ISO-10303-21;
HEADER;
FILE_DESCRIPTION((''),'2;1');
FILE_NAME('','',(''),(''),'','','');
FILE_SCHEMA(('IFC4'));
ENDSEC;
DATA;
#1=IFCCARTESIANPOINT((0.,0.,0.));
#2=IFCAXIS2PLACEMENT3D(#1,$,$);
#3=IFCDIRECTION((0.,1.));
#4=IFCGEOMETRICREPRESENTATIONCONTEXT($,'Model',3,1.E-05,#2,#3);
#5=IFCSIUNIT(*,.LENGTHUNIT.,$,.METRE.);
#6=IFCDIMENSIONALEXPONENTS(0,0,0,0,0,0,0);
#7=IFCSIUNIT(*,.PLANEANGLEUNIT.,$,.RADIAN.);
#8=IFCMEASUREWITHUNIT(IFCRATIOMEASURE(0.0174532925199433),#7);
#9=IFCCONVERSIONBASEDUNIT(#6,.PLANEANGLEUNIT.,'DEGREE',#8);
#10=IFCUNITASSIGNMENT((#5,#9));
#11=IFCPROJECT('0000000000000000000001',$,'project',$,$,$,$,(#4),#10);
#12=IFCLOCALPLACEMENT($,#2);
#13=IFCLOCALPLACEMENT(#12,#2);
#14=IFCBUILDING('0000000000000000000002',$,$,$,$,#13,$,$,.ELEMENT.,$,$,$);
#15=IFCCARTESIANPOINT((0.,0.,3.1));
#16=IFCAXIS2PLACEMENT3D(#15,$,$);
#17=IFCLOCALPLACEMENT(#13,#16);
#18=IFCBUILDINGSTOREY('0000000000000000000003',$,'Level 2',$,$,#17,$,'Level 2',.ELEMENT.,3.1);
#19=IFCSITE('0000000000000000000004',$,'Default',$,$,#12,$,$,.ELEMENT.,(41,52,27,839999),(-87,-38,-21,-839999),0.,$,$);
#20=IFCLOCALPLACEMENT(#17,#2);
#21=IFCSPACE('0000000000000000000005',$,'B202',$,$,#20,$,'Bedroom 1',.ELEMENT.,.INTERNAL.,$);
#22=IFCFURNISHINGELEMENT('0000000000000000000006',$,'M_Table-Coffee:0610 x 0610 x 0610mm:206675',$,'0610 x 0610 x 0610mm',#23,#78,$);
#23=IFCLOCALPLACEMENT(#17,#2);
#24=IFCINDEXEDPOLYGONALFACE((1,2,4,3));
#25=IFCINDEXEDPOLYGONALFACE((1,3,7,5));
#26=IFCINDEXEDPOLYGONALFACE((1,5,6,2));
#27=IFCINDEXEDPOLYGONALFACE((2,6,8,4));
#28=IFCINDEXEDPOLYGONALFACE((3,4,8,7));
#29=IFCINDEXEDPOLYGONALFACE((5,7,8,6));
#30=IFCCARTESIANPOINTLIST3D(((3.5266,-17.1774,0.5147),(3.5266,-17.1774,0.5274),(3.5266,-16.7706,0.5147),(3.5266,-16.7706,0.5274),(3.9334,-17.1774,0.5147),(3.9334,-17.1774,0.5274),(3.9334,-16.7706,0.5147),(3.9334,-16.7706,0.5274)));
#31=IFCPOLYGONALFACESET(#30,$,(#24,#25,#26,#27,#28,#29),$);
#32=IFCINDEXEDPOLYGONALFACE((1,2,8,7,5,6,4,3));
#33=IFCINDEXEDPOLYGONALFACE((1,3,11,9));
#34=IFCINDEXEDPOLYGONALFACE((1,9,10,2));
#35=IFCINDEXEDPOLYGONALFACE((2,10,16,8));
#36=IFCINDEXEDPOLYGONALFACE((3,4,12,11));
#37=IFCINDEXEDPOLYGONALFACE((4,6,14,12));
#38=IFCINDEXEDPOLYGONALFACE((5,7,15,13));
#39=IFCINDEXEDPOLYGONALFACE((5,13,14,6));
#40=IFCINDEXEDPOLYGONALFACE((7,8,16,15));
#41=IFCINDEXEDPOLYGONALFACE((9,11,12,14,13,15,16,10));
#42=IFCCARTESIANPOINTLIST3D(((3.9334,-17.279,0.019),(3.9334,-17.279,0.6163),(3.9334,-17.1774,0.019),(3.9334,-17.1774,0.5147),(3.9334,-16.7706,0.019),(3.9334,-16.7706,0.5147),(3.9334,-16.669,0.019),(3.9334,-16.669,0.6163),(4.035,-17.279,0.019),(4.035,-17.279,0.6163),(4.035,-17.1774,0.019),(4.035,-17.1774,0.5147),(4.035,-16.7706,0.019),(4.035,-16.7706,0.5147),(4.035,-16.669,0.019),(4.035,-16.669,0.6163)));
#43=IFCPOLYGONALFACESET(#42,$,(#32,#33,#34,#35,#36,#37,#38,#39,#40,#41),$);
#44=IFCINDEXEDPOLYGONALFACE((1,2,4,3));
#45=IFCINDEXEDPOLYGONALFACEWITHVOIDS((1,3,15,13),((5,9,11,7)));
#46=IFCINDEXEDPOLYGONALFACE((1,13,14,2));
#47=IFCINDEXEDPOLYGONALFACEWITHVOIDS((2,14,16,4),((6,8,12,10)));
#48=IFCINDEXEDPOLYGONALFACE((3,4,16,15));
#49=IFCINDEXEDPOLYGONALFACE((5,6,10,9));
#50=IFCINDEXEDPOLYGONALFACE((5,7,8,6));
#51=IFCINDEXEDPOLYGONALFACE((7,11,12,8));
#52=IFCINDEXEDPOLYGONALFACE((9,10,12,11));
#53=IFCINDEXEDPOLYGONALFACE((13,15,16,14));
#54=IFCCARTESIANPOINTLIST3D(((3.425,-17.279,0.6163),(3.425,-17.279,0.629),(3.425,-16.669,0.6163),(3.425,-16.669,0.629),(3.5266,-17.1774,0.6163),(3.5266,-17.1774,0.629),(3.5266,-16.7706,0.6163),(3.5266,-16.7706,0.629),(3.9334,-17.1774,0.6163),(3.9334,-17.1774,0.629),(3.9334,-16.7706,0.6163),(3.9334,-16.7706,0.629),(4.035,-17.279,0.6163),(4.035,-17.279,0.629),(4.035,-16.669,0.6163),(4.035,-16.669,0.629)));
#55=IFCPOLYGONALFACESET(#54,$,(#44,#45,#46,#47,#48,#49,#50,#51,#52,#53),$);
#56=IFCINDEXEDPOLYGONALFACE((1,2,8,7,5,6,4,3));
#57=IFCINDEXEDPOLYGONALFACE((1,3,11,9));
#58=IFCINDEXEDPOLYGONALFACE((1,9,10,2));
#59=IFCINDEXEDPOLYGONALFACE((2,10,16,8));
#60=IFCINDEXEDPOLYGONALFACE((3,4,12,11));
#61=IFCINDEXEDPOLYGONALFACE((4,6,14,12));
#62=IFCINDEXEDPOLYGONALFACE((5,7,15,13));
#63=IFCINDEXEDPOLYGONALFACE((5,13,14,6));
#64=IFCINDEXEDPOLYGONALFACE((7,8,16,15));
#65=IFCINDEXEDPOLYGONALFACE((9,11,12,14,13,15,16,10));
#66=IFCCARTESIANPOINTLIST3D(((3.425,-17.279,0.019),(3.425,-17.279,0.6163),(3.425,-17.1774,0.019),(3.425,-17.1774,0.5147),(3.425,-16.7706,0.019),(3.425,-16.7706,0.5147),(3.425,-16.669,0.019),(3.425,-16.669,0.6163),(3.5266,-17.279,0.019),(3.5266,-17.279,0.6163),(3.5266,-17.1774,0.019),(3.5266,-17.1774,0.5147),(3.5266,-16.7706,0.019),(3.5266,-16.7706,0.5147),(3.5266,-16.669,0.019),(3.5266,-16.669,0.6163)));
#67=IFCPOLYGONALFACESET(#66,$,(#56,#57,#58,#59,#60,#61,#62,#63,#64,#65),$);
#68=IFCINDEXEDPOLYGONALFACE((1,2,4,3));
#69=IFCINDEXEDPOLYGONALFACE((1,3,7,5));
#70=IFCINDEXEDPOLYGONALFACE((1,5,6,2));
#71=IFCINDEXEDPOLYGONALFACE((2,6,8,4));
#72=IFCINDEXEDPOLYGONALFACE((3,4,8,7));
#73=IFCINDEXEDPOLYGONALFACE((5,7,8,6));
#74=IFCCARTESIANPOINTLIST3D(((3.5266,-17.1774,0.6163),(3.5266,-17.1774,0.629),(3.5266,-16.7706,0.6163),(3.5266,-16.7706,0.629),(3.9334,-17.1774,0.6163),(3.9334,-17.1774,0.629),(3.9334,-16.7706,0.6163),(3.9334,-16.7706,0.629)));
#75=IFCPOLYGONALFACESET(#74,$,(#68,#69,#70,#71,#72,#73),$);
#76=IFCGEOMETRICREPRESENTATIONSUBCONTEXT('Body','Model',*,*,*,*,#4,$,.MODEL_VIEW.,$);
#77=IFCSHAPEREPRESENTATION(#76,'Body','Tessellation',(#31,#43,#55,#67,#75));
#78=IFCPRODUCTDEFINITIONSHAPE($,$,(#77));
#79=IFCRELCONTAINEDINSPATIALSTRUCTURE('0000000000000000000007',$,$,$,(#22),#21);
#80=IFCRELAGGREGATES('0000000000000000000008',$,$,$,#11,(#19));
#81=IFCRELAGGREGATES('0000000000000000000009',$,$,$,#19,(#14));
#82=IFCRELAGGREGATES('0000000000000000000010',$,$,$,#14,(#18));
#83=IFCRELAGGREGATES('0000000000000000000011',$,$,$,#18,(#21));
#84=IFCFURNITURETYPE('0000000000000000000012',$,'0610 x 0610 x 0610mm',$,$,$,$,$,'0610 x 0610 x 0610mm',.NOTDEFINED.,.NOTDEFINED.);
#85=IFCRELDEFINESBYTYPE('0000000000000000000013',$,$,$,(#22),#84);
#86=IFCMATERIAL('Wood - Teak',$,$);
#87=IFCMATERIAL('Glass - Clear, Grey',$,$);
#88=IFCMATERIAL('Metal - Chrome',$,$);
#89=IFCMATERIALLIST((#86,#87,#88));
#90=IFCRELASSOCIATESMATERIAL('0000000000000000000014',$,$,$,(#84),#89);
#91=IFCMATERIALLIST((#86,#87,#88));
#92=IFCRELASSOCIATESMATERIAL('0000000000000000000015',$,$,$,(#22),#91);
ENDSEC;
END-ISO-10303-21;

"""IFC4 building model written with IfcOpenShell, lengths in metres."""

from ifc_helpers import new_model, entity, si_unit, converted_unit, direction, frame, origin, origin_2d_with_axis, place, context, subcontext, project, spatial, polyline, rectangle, outline, extrude, source, transform, mapped, material, material_list, type_object, type_shapes, element, save


model = new_model("IFC4")

# Units and contexts
model_context = context("Model", 3, precision=1e-05, world=origin(), true_north=direction((0.0, 1.0)))
body_context = subcontext(model_context, "Body", "Model", "MODEL_VIEW")
ifc_project = project(units=[si_unit("LENGTHUNIT", "METRE"), converted_unit("PLANEANGLEUNIT", "DEGREE", entity("IfcRatioMeasure", 0.0174532925199433), si_unit("PLANEANGLEUNIT", "RADIAN"), dimensions=[0, 0, 0, 0, 0, 0, 0])], contexts=[model_context])

# Site, building, storey
site_placement = place(None, origin())
site = spatial("IfcSite", under=ifc_project, at=site_placement, Name="Default", CompositionType="ELEMENT", RefLatitude=(41, 52, 27, 839999), RefLongitude=(-87, -38, -21, -839999), RefElevation=0.0)
building_placement = place(site_placement, origin())
building = spatial("IfcBuilding", under=site, at=building_placement, CompositionType="ELEMENT")
storey_placement = place(building_placement, frame((0.0, 0.0, 3.1)))
storey = spatial("IfcBuildingStorey", under=building, at=storey_placement, Name="Level 2", LongName="Level 2", CompositionType="ELEMENT", Elevation=3.1)

# Shared definitions
space_placement = place(storey_placement, origin())
space = spatial("IfcSpace", under=storey, at=space_placement, Name="B202", LongName="Bedroom 1", CompositionType="ELEMENT", PredefinedType="INTERNAL")

# Furnishing element
ifc_material_1 = material(Name="Wood - Teak")
ifc_material_2 = material(Name="Glass - Clear, Grey")
ifc_material_3 = material(Name="Metal - Chrome")
ifc_material_list_1 = material_list([ifc_material_1, ifc_material_2, ifc_material_3])
ifc_material_list_2 = material_list([ifc_material_1, ifc_material_2, ifc_material_3])
furniture_type_1 = type_object("IfcFurnitureType", Name="0610 x 0610 x 0610mm", ElementType="0610 x 0610 x 0610mm", AssemblyPlace="NOTDEFINED", material=ifc_material_list_2)
shared_shape_1 = source(origin(), body_context, "Body", "SweptSolid", [
    extrude(rectangle(XDim=0.4068, YDim=0.4068, at=origin_2d_with_axis()), frame((0.0183, 0.0952, 0.4957), z_axis=(0.0, 0.0, 1.0), x_axis=(-1.0, 0.0, 0.0)), (0.0, 0.0, 1.0), 0.0127),
    extrude(outline(polyline([(-0.2732, -0.305), (0.324, -0.305), (0.324, 0.305), (-0.2732, 0.305), (-0.2732, 0.2034), (0.2225, 0.2034), (0.2225, -0.2034), (-0.2732, -0.2034), (-0.2732, -0.305)])), frame((0.2217, 0.0952, 0.2732), z_axis=(1.0, 0.0, 0.0), x_axis=(0.0, 0.0, 1.0)), (0.0, 0.0, 1.0), 0.1016),
    extrude(outline(polyline([(-0.305, -0.305), (0.305, -0.305), (0.305, 0.305), (-0.305, 0.305), (-0.305, -0.305)]), holes=[polyline([(-0.2034, -0.2034), (-0.2034, 0.2034), (0.2034, 0.2034), (0.2034, -0.2034), (-0.2034, -0.2034)])]), frame((0.0183, 0.0952, 0.5973), z_axis=(0.0, 0.0, 1.0), x_axis=(-1.0, 0.0, 0.0)), (0.0, 0.0, 1.0), 0.0127),
    extrude(outline(polyline([(-0.305, -0.3241), (0.305, -0.3241), (0.305, 0.2733), (0.2034, 0.2733), (0.2034, -0.2224), (-0.2034, -0.2224), (-0.2034, 0.2733), (-0.305, 0.2733), (-0.305, -0.3241)])), frame((-0.2867, 0.0952, 0.2733), z_axis=(1.0, 0.0, 0.0), x_axis=(0.0, -1.0, 0.0)), (0.0, 0.0, 1.0), 0.1016),
    extrude(rectangle(XDim=0.4068, YDim=0.4068, at=origin_2d_with_axis()), frame((0.0183, 0.0952, 0.5973), z_axis=(0.0, 0.0, 1.0), x_axis=(-1.0, 0.0, 0.0)), (0.0, 0.0, 1.0), 0.0127),
])
type_shapes(furniture_type_1, [shared_shape_1])
furnishing_1_placement = place(space_placement, frame((3.7117, -17.0692, 0.019)))
element("IfcFurnishingElement", 1, at=furnishing_1_placement, inside=space, type_object=furniture_type_1, material=ifc_material_list_1, Name="M_Table-Coffee:0610 x 0610 x 0610mm:206675", ObjectType="0610 x 0610 x 0610mm", context=body_context, shape_type="MappedRepresentation", body=[
    mapped(shared_shape_1, transform((0.0, 0.0, 0.0), scale=1.0)),
])

save(model, "model.ifc")
